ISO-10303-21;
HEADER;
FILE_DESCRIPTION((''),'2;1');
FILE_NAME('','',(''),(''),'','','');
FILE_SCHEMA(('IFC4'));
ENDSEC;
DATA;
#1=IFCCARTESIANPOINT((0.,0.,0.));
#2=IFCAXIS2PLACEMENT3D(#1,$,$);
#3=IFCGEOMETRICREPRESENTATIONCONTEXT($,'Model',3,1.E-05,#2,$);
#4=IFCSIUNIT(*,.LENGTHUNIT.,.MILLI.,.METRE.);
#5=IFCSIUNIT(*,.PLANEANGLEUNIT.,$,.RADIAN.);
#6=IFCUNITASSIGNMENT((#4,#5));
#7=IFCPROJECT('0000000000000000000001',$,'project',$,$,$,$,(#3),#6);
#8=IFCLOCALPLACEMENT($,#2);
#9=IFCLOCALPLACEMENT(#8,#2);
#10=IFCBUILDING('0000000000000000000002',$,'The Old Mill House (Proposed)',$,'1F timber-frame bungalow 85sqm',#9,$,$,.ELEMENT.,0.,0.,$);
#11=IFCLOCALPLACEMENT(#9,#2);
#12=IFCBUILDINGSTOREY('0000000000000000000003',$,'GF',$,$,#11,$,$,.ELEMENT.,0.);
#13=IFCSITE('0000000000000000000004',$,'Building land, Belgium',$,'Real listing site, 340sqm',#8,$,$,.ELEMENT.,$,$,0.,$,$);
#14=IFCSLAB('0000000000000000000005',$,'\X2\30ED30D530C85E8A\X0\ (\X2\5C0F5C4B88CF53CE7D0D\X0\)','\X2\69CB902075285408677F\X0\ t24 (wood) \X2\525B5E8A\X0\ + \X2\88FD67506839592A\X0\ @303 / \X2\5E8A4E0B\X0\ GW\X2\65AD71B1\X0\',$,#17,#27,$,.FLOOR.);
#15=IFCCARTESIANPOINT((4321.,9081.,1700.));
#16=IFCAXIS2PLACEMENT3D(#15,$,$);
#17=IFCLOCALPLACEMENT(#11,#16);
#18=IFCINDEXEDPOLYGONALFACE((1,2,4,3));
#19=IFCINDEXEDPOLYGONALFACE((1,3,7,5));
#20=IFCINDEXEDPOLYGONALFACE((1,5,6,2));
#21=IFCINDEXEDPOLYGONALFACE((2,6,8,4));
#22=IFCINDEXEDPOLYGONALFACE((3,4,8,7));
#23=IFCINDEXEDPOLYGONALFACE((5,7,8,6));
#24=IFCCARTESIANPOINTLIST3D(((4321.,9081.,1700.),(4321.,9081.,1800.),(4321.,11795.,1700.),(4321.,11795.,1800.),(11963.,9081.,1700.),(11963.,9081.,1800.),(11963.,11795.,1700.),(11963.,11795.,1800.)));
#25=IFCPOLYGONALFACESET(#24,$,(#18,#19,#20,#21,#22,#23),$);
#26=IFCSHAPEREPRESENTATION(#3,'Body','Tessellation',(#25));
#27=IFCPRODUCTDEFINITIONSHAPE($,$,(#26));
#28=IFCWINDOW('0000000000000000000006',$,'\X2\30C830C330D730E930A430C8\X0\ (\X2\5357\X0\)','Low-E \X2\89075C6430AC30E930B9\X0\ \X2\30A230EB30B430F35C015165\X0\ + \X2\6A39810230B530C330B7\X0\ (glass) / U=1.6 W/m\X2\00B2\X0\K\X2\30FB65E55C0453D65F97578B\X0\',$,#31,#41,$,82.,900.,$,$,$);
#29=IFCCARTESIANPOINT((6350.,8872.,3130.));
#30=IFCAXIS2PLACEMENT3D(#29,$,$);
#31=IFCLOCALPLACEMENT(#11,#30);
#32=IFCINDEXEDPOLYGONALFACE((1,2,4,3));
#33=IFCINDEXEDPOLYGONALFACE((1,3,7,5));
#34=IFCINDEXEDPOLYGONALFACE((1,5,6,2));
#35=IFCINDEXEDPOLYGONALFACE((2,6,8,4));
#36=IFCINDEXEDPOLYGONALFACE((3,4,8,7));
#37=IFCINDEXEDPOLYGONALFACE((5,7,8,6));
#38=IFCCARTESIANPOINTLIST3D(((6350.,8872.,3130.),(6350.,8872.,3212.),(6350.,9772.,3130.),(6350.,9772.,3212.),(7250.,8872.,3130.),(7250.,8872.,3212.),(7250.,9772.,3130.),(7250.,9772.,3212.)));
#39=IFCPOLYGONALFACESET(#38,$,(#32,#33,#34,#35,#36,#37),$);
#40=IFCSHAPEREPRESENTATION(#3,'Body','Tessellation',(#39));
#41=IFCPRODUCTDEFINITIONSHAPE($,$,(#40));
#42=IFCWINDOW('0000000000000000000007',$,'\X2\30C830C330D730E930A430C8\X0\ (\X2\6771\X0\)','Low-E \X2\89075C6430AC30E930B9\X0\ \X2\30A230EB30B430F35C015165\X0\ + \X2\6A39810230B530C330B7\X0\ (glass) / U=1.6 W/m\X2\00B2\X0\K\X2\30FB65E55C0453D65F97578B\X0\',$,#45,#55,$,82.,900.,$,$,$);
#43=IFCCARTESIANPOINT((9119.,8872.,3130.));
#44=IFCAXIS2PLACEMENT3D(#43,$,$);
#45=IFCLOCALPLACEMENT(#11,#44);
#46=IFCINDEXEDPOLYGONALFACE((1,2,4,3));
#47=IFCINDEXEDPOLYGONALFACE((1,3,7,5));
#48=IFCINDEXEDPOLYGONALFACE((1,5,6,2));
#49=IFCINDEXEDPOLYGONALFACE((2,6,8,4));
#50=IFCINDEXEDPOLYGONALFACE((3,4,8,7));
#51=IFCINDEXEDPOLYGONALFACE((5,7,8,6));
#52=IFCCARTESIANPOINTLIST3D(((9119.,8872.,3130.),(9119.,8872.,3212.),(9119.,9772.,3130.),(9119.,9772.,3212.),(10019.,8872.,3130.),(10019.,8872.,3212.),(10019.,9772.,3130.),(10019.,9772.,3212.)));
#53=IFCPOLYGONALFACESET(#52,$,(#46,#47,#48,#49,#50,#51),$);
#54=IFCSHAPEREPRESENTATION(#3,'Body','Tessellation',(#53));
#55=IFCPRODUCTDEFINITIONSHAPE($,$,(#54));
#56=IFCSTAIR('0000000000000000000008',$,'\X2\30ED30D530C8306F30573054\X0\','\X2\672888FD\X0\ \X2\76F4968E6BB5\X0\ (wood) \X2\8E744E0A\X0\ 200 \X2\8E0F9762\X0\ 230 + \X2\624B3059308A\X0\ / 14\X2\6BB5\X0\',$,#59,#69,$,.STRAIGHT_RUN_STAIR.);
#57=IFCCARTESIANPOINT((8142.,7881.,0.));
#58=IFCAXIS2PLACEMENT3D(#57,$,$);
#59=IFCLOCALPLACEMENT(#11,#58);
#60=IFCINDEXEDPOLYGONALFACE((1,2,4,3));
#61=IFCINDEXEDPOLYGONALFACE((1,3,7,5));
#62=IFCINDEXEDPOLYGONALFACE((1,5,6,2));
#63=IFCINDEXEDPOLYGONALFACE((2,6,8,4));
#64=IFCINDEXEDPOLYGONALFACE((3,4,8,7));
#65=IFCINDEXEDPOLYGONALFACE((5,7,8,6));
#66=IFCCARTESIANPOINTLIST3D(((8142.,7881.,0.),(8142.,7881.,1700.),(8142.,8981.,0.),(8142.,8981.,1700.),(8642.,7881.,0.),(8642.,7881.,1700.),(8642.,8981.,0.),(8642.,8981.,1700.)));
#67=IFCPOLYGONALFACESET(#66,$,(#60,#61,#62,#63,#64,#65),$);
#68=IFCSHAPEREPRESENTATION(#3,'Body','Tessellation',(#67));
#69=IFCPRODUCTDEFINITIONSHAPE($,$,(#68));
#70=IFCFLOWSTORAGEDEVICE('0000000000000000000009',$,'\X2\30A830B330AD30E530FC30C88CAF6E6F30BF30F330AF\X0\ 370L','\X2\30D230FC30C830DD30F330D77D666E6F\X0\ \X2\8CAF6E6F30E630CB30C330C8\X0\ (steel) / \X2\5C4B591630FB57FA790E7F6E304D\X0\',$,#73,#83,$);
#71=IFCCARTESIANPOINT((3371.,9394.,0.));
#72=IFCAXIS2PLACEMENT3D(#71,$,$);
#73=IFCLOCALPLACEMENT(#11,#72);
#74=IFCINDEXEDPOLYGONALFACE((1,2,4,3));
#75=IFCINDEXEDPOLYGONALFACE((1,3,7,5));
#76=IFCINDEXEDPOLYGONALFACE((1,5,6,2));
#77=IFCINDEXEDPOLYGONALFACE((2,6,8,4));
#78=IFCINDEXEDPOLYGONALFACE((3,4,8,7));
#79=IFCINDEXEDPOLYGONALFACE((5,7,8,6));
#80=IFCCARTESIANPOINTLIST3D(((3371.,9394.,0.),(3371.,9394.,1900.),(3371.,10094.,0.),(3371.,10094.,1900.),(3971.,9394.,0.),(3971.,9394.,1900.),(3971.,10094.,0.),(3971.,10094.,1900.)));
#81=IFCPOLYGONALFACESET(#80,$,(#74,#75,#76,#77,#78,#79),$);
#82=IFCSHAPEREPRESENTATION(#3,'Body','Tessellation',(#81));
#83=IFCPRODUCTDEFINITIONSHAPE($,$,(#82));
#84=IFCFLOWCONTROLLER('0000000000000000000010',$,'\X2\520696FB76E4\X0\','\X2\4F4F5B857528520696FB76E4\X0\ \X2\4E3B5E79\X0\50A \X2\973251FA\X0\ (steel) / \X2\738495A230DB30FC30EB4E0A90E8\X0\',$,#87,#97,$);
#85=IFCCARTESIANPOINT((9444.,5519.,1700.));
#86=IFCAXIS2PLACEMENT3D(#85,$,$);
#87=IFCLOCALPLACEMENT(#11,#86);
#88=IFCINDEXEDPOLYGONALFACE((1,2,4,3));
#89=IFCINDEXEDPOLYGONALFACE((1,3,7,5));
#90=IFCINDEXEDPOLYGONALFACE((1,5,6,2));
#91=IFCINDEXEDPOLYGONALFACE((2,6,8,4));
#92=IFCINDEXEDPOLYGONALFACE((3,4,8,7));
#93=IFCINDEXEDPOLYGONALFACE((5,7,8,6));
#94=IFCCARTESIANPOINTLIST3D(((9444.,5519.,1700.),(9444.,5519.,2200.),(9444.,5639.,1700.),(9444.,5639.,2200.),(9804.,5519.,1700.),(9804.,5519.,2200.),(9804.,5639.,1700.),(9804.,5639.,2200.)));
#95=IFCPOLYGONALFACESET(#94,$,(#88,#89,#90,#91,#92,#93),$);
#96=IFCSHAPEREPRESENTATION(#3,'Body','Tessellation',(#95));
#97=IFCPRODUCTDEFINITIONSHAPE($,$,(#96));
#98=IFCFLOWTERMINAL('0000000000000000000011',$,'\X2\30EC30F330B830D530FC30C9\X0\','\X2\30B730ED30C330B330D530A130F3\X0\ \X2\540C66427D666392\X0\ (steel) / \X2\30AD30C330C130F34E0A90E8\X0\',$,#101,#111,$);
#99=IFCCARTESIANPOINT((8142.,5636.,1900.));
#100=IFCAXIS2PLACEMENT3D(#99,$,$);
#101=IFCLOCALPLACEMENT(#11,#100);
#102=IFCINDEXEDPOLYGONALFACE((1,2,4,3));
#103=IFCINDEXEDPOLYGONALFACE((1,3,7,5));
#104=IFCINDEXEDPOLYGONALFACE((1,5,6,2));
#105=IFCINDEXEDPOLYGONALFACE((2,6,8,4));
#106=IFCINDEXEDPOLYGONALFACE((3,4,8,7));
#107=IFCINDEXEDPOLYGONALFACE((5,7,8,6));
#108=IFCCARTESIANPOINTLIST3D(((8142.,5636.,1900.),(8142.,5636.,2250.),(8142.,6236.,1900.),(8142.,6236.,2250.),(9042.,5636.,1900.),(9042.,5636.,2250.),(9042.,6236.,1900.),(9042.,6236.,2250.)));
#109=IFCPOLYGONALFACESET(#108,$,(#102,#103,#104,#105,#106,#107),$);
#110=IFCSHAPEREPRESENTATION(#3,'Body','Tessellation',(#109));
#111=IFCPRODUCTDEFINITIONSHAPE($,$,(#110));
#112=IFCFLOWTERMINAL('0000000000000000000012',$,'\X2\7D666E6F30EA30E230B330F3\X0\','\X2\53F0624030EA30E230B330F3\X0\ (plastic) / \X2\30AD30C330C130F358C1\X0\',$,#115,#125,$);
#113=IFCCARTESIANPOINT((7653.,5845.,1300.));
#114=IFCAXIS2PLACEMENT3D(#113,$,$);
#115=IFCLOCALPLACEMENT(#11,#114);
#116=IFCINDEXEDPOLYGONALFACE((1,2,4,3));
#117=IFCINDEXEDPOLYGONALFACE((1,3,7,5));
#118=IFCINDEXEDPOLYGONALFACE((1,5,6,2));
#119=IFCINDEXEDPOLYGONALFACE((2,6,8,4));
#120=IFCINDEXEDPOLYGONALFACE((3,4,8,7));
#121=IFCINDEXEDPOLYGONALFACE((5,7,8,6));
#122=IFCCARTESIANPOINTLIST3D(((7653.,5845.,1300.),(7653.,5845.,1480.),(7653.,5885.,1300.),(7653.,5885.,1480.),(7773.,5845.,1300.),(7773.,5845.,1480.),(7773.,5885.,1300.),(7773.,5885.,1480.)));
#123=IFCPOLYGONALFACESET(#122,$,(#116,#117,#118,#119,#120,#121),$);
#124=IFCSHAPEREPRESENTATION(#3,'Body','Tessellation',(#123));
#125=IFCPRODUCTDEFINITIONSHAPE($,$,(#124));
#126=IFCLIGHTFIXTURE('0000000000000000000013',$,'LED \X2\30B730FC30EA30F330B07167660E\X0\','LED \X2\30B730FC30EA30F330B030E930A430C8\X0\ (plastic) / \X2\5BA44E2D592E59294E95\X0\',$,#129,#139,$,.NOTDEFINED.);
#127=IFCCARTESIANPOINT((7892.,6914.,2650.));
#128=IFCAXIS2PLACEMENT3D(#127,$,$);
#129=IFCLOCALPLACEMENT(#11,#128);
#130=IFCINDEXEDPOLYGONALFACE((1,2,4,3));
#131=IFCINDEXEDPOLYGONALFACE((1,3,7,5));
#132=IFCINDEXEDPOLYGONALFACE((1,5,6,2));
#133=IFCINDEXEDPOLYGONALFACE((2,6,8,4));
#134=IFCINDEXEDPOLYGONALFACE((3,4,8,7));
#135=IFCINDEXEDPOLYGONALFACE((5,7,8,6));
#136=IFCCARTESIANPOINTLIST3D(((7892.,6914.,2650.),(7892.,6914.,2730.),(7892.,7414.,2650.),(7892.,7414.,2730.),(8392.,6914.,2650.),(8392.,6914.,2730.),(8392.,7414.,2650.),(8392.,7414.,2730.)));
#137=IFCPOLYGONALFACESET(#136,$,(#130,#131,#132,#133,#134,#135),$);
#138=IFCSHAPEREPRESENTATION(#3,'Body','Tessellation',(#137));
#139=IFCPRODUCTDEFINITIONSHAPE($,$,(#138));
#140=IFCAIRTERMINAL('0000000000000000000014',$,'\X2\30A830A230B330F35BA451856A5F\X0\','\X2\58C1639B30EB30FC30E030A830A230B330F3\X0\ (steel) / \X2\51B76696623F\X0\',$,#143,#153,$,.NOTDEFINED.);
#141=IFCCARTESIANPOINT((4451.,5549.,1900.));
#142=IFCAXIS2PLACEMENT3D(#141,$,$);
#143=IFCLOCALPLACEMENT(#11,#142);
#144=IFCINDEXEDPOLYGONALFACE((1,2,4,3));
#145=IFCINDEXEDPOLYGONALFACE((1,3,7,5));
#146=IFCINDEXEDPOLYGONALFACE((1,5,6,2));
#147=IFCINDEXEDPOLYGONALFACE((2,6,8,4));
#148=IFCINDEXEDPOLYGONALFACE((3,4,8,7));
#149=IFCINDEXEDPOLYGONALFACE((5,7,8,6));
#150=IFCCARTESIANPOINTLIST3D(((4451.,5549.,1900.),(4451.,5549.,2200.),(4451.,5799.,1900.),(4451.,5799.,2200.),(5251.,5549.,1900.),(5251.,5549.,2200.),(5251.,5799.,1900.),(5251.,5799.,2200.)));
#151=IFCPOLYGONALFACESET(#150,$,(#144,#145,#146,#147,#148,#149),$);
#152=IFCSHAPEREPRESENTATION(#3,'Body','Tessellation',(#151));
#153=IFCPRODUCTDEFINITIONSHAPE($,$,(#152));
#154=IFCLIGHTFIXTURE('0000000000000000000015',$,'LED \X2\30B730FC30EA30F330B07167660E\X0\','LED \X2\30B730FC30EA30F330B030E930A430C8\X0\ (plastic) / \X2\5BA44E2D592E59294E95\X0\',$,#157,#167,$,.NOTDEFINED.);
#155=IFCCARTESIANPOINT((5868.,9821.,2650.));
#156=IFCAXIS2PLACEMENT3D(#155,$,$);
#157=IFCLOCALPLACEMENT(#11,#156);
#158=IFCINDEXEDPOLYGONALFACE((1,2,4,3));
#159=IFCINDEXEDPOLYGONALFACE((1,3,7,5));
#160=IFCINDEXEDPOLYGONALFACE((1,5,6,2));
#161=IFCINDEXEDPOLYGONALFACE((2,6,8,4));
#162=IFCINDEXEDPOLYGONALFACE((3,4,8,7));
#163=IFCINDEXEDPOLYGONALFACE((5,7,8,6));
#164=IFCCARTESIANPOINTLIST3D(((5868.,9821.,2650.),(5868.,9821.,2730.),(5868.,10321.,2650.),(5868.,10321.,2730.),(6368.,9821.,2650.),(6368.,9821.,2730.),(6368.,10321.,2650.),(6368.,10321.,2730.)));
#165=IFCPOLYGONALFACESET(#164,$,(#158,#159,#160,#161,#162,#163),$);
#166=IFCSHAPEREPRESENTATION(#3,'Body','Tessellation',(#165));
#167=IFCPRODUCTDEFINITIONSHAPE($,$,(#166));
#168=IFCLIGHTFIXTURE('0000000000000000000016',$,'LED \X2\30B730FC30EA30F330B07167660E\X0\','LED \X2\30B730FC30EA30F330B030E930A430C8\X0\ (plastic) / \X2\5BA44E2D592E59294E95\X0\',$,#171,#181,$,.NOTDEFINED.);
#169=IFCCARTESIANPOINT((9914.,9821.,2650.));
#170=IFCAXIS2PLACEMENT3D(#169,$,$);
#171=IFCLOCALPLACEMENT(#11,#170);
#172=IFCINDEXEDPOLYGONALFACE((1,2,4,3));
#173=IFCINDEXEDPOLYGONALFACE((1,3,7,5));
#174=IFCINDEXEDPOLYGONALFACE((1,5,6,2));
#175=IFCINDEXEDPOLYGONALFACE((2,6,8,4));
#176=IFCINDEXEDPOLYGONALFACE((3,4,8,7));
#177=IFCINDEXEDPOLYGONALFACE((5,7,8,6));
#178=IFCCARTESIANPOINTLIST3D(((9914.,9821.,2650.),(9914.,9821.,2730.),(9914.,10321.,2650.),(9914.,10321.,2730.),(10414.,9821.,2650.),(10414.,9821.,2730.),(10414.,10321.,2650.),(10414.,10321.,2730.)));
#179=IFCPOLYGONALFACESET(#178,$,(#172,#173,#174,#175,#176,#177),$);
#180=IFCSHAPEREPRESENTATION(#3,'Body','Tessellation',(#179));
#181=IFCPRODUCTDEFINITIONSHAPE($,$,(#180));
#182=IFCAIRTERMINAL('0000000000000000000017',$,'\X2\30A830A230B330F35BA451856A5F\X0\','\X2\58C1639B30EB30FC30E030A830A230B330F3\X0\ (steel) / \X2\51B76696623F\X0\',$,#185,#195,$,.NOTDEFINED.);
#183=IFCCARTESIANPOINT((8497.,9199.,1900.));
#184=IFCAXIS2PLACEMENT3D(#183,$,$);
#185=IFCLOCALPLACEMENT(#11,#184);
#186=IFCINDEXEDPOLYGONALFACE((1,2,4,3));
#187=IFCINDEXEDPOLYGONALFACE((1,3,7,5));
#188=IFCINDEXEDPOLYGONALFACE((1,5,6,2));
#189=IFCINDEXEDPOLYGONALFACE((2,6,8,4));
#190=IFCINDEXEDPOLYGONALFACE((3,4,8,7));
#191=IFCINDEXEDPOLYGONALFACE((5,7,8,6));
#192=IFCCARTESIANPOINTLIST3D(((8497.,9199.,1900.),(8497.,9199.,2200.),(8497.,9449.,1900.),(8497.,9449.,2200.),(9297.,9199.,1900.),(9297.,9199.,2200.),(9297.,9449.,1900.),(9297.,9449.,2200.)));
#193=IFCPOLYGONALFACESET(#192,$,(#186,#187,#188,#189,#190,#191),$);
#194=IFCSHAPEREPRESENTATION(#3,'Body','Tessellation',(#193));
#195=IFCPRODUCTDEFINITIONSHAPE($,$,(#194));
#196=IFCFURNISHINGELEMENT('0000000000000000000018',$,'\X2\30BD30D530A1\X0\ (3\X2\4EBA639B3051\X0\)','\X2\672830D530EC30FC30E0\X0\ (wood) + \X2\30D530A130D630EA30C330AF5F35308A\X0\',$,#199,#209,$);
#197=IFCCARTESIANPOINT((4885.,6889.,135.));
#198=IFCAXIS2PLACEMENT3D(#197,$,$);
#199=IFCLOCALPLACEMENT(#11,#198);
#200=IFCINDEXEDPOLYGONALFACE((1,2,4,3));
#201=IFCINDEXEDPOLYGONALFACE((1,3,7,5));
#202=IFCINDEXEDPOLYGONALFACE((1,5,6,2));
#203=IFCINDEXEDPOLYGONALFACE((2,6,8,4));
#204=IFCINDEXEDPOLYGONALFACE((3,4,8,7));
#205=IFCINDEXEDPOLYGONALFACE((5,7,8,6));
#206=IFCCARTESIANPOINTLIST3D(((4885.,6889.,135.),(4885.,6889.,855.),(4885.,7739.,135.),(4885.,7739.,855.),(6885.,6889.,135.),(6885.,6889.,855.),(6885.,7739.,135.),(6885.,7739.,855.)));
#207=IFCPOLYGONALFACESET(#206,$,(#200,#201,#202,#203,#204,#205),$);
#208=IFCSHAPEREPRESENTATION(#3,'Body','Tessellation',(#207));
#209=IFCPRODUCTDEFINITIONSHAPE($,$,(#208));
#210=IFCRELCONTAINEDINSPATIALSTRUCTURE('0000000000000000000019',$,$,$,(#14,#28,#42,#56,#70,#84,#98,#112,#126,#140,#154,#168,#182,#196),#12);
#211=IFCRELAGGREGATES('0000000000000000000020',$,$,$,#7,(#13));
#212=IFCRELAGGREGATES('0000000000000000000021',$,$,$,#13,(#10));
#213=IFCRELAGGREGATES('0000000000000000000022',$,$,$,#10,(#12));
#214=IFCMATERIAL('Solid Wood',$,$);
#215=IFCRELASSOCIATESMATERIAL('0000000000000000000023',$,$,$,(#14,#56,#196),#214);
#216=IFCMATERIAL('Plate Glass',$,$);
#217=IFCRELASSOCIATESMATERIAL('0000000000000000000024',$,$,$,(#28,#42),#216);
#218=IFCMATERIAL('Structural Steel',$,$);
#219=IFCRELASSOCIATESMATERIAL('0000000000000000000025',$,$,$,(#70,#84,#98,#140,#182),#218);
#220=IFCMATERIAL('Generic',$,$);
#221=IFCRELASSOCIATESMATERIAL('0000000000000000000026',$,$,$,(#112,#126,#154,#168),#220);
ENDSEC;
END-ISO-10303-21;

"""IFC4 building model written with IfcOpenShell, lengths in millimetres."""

from ifc_helpers import new_model, si_unit, frame, frame_2d, origin, place, context, project, spatial, rectangle, extrude, material, element, save


model = new_model("IFC4")

# Units and contexts
model_context = context("Model", 3, precision=1e-05, world=origin())
ifc_project = project(units=[si_unit("LENGTHUNIT", "METRE", prefix="MILLI"), si_unit("PLANEANGLEUNIT", "RADIAN")], contexts=[model_context])

# Site, building, storey
site_placement = place(None, origin())
site = spatial("IfcSite", under=ifc_project, at=site_placement, Name="Building land, Belgium", ObjectType="Real listing site, 340sqm", CompositionType="ELEMENT", RefElevation=0.0)
building_placement = place(site_placement, origin())
building = spatial("IfcBuilding", under=site, at=building_placement, Name="The Old Mill House (Proposed)", ObjectType="1F timber-frame bungalow 85sqm", CompositionType="ELEMENT", ElevationOfRefHeight=0.0, ElevationOfTerrain=0.0)
storey_placement = place(building_placement, origin())
storey = spatial("IfcBuildingStorey", under=building, at=storey_placement, Name="GF", CompositionType="ELEMENT", Elevation=0.0)

# Shared definitions
ifc_material_1 = material(Name="Solid Wood")

# Slab
slab_placement = place(storey_placement, frame((4321.0, 9081.0, 1700.0)))
element("IfcSlab", 1, at=slab_placement, inside=storey, material=ifc_material_1, Name="ロフト床 (小屋裏収納)", Description="構造用合板 t24 (wood) 剛床 + 製材根太 @303 / 床下 GW断熱", PredefinedType="FLOOR", context=model_context, shape_type="SweptSolid", body=[
    extrude(rectangle(XDim=7642.0, YDim=2714.0, at=frame_2d((3821.0, 1357.0))), frame((4321.0, 9081.0, 1700.0)), (0.0, 0.0, 1.0), 100.0),
])

# Windows
ifc_material_2 = material(Name="Plate Glass")
window_1_placement = place(storey_placement, frame((6350.0, 8872.0, 3130.0)))
element("IfcWindow", 2, at=window_1_placement, inside=storey, material=ifc_material_2, Name="トップライト (南)", Description="Low-E 複層ガラス アルゴン封入 + 樹脂サッシ (glass) / U=1.6 W/m²K・日射取得型", OverallHeight=82.0, OverallWidth=900.0, context=model_context, shape_type="SweptSolid", body=[
    extrude(rectangle(XDim=900.0, YDim=900.0, at=frame_2d((450.0, 450.0))), frame((6350.0, 8872.0, 3130.0)), (0.0, 0.0, 1.0), 82.0),
])
window_2_placement = place(storey_placement, frame((9119.0, 8872.0, 3130.0)))
element("IfcWindow", 3, at=window_2_placement, inside=storey, material=ifc_material_2, Name="トップライト (東)", Description="Low-E 複層ガラス アルゴン封入 + 樹脂サッシ (glass) / U=1.6 W/m²K・日射取得型", OverallHeight=82.0, OverallWidth=900.0, context=model_context, shape_type="SweptSolid", body=[
    extrude(rectangle(XDim=900.0, YDim=900.0, at=frame_2d((450.0, 450.0))), frame((9119.0, 8872.0, 3130.0)), (0.0, 0.0, 1.0), 82.0),
])

# Stair
stair_placement = place(storey_placement, frame((8142.0, 7881.0, 0.0)))
element("IfcStair", 4, at=stair_placement, inside=storey, material=ifc_material_1, Name="ロフトはしご", Description="木製 直階段 (wood) 蹴上 200 踏面 230 + 手すり / 14段", PredefinedType="STRAIGHT_RUN_STAIR", context=model_context, shape_type="SweptSolid", body=[
    extrude(rectangle(XDim=500.0, YDim=1100.0, at=frame_2d((250.0, 550.0))), frame((8142.0, 7881.0, 0.0)), (0.0, 0.0, 1.0), 1700.0),
])

# Flow storage device
ifc_material_3 = material(Name="Structural Steel")
flow_storage_device_placement = place(storey_placement, frame((3371.0, 9394.0, 0.0)))
element("IfcFlowStorageDevice", 5, at=flow_storage_device_placement, inside=storey, material=ifc_material_3, Name="エコキュート貯湯タンク 370L", Description="ヒートポンプ給湯 貯湯ユニット (steel) / 屋外・基礎置き", context=model_context, shape_type="SweptSolid", body=[
    extrude(rectangle(XDim=600.0, YDim=700.0, at=frame_2d((300.0, 350.0))), frame((3371.0, 9394.0, 0.0)), (0.0, 0.0, 1.0), 1900.0),
])

# Flow controller
flow_controller_placement = place(storey_placement, frame((9444.0, 5519.0, 1700.0)))
element("IfcFlowController", 6, at=flow_controller_placement, inside=storey, material=ifc_material_3, Name="分電盤", Description="住宅用分電盤 主幹50A 露出 (steel) / 玄関ホール上部", context=model_context, shape_type="SweptSolid", body=[
    extrude(rectangle(XDim=360.0, YDim=120.0, at=frame_2d((180.0, 60.0))), frame((9444.0, 5519.0, 1700.0)), (0.0, 0.0, 1.0), 500.0),
])

# Flow terminals
flow_terminal_1_placement = place(storey_placement, frame((8142.0, 5636.0, 1900.0)))
element("IfcFlowTerminal", 7, at=flow_terminal_1_placement, inside=storey, material=ifc_material_3, Name="レンジフード", Description="シロッコファン 同時給排 (steel) / キッチン上部", context=model_context, shape_type="SweptSolid", body=[
    extrude(rectangle(XDim=900.0, YDim=600.0, at=frame_2d((450.0, 300.0))), frame((8142.0, 5636.0, 1900.0)), (0.0, 0.0, 1.0), 350.0),
])
ifc_material_4 = material(Name="Generic")
flow_terminal_2_placement = place(storey_placement, frame((7653.0, 5845.0, 1300.0)))
element("IfcFlowTerminal", 8, at=flow_terminal_2_placement, inside=storey, material=ifc_material_4, Name="給湯リモコン", Description="台所リモコン (plastic) / キッチン壁", context=model_context, shape_type="SweptSolid", body=[
    extrude(rectangle(XDim=120.0, YDim=40.0, at=frame_2d((60.0, 20.0))), frame((7653.0, 5845.0, 1300.0)), (0.0, 0.0, 1.0), 180.0),
])

# Light fixture
light_fixture_1_placement = place(storey_placement, frame((7892.0, 6914.0, 2650.0)))
element("IfcLightFixture", 9, at=light_fixture_1_placement, inside=storey, material=ifc_material_4, Name="LED シーリング照明", Description="LED シーリングライト (plastic) / 室中央天井", PredefinedType="NOTDEFINED", context=model_context, shape_type="SweptSolid", body=[
    extrude(rectangle(XDim=500.0, YDim=500.0, at=frame_2d((250.0, 250.0))), frame((7892.0, 6914.0, 2650.0)), (0.0, 0.0, 1.0), 80.0),
])

# Air terminal
air_terminal_1_placement = place(storey_placement, frame((4451.0, 5549.0, 1900.0)))
element("IfcAirTerminal", 10, at=air_terminal_1_placement, inside=storey, material=ifc_material_3, Name="エアコン室内機", Description="壁掛ルームエアコン (steel) / 冷暖房", PredefinedType="NOTDEFINED", context=model_context, shape_type="SweptSolid", body=[
    extrude(rectangle(XDim=800.0, YDim=250.0, at=frame_2d((400.0, 125.0))), frame((4451.0, 5549.0, 1900.0)), (0.0, 0.0, 1.0), 300.0),
])

# Light fixtures
light_fixture_2_placement = place(storey_placement, frame((5868.0, 9821.0, 2650.0)))
element("IfcLightFixture", 11, at=light_fixture_2_placement, inside=storey, material=ifc_material_4, Name="LED シーリング照明", Description="LED シーリングライト (plastic) / 室中央天井", PredefinedType="NOTDEFINED", context=model_context, shape_type="SweptSolid", body=[
    extrude(rectangle(XDim=500.0, YDim=500.0, at=frame_2d((250.0, 250.0))), frame((5868.0, 9821.0, 2650.0)), (0.0, 0.0, 1.0), 80.0),
])
light_fixture_3_placement = place(storey_placement, frame((9914.0, 9821.0, 2650.0)))
element("IfcLightFixture", 12, at=light_fixture_3_placement, inside=storey, material=ifc_material_4, Name="LED シーリング照明", Description="LED シーリングライト (plastic) / 室中央天井", PredefinedType="NOTDEFINED", context=model_context, shape_type="SweptSolid", body=[
    extrude(rectangle(XDim=500.0, YDim=500.0, at=frame_2d((250.0, 250.0))), frame((9914.0, 9821.0, 2650.0)), (0.0, 0.0, 1.0), 80.0),
])

# Air terminal
air_terminal_2_placement = place(storey_placement, frame((8497.0, 9199.0, 1900.0)))
element("IfcAirTerminal", 13, at=air_terminal_2_placement, inside=storey, material=ifc_material_3, Name="エアコン室内機", Description="壁掛ルームエアコン (steel) / 冷暖房", PredefinedType="NOTDEFINED", context=model_context, shape_type="SweptSolid", body=[
    extrude(rectangle(XDim=800.0, YDim=250.0, at=frame_2d((400.0, 125.0))), frame((8497.0, 9199.0, 1900.0)), (0.0, 0.0, 1.0), 300.0),
])

# Furnishing element
furnishing_1_placement = place(storey_placement, frame((4885.0, 6889.0, 135.0)))
element("IfcFurnishingElement", 14, at=furnishing_1_placement, inside=storey, material=ifc_material_1, Name="ソファ (3人掛け)", Description="木フレーム (wood) + ファブリック張り", context=model_context, shape_type="SweptSolid", body=[
    extrude(rectangle(XDim=2000.0, YDim=850.0, at=frame_2d((1000.0, 425.0))), frame((4885.0, 6889.0, 135.0)), (0.0, 0.0, 1.0), 720.0),
])

save(model, "model.ifc")
